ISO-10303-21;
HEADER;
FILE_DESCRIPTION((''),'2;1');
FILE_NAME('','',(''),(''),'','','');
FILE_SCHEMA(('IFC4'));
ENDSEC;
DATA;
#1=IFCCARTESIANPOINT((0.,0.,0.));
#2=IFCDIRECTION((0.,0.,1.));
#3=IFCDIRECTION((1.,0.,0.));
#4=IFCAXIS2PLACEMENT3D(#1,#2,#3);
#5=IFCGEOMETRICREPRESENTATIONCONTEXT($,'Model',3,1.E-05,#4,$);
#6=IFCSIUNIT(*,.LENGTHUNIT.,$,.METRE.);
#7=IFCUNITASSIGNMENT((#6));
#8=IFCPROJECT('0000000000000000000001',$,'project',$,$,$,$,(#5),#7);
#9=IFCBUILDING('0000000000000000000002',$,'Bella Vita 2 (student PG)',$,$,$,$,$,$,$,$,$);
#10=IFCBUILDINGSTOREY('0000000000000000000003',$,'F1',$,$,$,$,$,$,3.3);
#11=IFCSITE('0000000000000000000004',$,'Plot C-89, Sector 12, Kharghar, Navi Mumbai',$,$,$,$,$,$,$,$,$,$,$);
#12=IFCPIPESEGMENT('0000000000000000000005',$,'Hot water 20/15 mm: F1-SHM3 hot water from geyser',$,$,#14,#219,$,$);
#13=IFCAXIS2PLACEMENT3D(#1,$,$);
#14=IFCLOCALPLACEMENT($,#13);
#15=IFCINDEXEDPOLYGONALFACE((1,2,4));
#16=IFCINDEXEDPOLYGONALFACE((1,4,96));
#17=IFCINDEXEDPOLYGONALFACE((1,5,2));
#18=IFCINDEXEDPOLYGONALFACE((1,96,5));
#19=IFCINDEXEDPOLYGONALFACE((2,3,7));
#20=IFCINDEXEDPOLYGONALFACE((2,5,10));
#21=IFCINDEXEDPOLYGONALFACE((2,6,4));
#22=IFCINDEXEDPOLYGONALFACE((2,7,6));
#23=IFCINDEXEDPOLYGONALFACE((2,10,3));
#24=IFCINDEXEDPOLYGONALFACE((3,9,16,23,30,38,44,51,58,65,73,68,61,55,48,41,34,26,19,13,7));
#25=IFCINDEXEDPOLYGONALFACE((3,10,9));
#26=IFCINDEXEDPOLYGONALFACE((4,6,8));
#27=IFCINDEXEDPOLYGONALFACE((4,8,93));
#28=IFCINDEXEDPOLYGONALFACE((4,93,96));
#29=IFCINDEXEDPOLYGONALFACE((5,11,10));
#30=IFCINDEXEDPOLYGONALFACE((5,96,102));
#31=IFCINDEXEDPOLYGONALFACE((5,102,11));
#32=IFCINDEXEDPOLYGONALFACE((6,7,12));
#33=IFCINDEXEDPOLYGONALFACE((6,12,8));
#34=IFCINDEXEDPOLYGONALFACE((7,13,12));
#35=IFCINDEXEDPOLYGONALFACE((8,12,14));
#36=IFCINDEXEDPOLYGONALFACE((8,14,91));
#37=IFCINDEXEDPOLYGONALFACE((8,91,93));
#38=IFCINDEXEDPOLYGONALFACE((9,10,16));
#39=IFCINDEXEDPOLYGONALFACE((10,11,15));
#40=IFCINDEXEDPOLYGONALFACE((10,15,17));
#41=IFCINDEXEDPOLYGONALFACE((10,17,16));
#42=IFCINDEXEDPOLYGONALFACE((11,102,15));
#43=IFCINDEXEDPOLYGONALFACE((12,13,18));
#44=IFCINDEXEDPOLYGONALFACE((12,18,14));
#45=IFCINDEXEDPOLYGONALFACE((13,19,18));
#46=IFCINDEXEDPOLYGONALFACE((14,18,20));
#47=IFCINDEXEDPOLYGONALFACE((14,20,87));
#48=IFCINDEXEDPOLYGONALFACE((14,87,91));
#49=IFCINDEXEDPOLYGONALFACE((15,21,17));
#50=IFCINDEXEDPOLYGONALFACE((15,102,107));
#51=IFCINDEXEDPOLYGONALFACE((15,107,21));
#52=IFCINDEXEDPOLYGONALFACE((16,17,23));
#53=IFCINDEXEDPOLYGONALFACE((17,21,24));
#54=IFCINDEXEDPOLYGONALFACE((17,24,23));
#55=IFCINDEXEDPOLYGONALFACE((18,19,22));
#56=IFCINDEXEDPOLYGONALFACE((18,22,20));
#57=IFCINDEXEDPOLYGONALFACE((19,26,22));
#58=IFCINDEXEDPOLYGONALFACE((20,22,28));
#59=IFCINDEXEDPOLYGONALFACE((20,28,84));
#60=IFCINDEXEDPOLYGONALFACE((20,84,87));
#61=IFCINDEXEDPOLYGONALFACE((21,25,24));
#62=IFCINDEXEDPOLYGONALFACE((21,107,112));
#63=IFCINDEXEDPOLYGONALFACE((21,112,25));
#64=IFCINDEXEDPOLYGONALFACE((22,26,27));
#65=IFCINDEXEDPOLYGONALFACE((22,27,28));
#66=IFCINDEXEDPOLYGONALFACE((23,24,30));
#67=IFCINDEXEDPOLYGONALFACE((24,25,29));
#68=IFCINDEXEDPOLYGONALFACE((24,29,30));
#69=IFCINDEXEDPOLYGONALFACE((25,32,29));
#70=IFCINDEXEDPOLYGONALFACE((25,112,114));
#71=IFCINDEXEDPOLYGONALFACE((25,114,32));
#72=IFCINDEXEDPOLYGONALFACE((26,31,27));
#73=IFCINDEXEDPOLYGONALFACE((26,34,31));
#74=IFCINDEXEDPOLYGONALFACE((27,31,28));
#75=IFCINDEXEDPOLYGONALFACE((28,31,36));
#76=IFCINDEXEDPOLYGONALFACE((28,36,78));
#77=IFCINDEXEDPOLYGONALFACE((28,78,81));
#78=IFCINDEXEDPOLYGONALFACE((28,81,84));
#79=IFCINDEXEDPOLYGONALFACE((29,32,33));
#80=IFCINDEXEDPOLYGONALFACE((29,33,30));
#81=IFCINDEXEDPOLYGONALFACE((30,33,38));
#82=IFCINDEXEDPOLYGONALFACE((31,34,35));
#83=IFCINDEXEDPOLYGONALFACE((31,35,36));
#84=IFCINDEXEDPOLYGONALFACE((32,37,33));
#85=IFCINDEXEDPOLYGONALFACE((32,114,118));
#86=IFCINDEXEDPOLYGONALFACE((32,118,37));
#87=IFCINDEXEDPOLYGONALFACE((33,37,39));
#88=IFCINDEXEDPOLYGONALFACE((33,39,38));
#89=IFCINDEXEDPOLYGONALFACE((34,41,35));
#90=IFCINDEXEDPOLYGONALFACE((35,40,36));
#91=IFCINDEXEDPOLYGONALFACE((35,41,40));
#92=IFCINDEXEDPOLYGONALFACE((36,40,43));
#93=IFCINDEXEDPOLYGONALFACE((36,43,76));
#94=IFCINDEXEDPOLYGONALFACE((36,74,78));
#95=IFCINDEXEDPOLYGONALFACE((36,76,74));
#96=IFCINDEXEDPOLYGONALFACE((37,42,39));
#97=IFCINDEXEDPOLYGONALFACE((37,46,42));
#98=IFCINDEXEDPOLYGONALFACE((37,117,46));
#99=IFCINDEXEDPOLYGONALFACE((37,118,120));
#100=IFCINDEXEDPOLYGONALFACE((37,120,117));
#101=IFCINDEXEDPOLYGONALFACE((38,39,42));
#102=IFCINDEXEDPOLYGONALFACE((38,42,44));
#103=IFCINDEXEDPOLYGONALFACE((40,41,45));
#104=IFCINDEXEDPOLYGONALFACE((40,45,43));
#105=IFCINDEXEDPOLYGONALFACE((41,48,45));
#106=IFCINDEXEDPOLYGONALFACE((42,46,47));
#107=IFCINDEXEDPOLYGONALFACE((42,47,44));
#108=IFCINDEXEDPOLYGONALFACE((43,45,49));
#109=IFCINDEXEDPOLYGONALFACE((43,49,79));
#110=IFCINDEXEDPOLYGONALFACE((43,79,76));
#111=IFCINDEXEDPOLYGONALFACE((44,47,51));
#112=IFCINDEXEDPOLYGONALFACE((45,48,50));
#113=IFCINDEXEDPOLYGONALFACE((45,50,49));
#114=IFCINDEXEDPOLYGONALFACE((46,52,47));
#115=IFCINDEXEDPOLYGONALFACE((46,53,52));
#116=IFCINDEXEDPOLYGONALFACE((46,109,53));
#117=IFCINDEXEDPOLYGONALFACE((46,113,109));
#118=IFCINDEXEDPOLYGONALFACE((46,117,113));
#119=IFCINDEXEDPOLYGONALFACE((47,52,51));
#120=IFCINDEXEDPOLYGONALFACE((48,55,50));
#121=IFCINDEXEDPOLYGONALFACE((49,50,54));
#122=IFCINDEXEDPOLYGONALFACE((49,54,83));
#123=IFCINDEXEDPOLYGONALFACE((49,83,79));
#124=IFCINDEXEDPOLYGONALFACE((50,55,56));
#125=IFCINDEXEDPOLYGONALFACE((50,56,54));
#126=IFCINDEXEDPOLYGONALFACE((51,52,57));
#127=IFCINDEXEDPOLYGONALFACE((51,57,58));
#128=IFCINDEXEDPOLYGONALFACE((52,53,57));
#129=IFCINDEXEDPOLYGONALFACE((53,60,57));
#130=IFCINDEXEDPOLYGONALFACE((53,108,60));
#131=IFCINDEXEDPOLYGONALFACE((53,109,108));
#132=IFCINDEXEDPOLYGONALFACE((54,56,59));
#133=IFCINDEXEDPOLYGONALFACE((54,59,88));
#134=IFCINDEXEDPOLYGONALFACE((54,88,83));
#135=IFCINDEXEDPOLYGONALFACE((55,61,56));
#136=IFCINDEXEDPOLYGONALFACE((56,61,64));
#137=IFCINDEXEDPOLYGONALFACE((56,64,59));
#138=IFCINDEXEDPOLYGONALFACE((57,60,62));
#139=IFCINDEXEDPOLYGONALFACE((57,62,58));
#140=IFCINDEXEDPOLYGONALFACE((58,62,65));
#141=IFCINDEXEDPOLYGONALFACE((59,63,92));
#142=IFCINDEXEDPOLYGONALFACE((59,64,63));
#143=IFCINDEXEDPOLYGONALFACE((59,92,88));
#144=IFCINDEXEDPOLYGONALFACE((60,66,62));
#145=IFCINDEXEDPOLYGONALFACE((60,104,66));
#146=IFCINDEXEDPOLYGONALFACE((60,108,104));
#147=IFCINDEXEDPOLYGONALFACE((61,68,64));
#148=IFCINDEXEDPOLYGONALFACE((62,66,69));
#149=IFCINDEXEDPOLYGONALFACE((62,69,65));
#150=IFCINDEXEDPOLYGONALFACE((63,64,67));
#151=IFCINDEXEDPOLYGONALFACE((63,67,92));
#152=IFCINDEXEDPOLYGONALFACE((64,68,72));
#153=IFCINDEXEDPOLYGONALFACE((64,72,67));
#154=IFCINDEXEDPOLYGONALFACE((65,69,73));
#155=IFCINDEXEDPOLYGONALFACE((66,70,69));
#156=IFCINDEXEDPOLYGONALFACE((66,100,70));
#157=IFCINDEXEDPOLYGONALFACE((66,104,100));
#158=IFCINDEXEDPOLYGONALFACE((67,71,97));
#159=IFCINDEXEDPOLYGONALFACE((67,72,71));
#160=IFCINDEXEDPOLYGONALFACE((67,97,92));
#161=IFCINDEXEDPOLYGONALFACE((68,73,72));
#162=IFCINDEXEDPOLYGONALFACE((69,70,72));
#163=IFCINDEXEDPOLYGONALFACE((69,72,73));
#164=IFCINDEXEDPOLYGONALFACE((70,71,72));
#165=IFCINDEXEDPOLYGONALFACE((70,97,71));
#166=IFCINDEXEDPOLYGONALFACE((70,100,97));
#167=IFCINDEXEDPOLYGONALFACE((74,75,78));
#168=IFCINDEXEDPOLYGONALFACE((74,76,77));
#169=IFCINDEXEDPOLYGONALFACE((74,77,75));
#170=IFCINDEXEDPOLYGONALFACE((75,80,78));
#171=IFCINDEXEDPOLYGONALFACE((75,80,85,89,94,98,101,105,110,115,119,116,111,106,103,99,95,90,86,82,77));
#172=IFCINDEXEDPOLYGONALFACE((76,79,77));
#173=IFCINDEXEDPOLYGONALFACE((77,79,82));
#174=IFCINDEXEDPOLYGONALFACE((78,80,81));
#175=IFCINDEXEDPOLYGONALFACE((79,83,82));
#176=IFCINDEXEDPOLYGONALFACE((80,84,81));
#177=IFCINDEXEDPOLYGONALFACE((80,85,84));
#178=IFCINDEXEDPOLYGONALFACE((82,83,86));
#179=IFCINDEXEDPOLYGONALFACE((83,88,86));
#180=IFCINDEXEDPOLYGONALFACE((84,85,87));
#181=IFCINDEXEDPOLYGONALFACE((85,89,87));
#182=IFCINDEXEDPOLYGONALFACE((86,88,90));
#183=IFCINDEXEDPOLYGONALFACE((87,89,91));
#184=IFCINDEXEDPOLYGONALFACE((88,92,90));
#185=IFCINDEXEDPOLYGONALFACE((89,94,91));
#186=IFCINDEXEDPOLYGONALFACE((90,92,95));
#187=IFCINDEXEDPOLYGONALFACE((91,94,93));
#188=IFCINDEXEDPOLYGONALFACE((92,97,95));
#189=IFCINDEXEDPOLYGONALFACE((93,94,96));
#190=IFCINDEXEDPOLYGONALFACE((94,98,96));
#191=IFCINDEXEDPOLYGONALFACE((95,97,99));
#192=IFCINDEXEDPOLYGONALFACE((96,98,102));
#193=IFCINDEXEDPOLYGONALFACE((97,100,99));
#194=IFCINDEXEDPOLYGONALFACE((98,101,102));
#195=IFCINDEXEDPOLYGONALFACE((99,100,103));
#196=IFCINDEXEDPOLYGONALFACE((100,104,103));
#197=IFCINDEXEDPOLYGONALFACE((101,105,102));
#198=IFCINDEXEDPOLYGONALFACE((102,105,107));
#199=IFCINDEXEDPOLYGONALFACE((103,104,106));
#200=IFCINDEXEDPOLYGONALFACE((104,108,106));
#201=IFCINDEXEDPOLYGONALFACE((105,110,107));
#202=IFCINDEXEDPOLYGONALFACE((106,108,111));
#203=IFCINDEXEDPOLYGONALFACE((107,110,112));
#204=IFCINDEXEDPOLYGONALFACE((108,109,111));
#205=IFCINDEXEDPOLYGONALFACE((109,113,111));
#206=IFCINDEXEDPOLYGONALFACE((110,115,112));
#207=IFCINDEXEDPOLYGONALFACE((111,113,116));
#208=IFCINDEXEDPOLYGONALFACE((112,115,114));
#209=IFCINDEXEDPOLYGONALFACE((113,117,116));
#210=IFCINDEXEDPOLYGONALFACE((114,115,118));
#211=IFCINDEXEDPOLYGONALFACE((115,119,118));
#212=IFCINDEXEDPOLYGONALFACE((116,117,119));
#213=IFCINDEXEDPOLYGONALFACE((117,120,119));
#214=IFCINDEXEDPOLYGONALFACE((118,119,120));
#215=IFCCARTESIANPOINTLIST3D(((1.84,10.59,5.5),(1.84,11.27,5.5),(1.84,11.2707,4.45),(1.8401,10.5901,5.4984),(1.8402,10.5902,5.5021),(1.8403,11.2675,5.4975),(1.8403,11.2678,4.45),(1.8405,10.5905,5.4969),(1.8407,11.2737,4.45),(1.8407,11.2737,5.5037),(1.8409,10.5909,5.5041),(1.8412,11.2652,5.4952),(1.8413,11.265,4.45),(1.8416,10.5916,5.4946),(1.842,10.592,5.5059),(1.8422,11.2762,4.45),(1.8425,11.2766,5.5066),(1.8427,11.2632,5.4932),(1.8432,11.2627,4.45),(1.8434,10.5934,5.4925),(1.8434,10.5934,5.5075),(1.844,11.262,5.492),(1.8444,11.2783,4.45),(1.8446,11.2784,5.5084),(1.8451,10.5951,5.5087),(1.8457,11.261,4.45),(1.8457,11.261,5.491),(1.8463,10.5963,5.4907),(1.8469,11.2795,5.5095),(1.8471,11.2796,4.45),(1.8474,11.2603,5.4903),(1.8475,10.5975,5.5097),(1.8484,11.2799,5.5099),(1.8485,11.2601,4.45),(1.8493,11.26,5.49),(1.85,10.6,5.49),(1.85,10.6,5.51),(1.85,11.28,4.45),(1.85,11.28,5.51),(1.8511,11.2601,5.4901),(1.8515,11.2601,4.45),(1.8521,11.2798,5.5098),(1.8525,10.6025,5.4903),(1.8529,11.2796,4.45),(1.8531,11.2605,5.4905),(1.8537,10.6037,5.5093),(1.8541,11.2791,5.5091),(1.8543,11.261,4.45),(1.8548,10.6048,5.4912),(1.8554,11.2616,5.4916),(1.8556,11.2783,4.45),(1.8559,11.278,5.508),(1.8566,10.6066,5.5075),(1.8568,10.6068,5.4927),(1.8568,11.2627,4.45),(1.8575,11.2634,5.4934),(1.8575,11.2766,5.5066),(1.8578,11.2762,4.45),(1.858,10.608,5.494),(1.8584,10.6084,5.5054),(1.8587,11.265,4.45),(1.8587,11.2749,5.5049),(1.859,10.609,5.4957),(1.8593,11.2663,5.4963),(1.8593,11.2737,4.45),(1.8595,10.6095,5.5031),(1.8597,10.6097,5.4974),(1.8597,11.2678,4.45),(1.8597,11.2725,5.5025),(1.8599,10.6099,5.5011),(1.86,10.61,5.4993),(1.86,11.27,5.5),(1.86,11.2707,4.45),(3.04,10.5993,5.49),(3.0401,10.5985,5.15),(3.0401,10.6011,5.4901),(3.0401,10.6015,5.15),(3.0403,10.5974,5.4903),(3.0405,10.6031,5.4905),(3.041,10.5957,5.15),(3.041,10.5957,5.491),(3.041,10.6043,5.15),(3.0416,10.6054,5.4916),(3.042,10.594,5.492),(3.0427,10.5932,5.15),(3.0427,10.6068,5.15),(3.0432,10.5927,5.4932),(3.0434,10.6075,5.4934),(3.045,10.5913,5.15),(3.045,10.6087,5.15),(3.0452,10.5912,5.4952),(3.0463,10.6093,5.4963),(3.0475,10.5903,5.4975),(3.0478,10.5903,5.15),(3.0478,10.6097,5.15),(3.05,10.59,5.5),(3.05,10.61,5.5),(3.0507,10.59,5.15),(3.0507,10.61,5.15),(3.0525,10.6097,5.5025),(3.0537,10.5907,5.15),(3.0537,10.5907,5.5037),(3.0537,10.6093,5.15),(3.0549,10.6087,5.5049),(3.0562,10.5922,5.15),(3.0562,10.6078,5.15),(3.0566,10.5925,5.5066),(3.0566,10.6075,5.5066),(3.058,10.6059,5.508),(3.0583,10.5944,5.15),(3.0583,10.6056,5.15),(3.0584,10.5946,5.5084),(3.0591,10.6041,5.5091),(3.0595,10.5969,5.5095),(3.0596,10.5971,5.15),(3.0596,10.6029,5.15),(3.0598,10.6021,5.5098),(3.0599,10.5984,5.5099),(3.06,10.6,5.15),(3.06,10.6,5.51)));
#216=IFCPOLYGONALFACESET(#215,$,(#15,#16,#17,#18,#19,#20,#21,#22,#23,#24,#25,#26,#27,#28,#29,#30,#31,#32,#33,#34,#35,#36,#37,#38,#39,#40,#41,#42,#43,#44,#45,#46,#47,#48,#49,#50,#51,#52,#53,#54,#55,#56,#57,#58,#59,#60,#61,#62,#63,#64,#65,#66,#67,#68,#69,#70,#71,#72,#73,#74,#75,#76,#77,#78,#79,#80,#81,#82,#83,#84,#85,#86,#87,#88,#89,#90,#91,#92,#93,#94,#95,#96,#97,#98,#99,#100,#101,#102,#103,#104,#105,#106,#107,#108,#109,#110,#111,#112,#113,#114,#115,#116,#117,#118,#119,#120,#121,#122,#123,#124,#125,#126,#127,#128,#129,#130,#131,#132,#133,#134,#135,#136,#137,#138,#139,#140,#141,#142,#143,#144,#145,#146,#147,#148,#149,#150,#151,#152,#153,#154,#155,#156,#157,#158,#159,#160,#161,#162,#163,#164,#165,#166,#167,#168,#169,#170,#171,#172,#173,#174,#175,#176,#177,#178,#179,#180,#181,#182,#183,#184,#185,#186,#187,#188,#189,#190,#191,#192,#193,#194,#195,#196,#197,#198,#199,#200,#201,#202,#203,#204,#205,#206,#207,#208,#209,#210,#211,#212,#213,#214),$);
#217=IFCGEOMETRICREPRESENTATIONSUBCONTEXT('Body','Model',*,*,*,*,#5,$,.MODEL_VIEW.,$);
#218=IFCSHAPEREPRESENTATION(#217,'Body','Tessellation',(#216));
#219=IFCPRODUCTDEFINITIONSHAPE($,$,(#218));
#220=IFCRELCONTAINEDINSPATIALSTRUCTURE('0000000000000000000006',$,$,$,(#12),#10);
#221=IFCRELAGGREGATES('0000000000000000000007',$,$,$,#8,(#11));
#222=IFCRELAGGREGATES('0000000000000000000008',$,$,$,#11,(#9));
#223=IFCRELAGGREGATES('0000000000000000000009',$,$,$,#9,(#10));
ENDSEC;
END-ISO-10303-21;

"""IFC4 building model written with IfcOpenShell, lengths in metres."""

from ifc_helpers import new_model, entity, si_unit, origin, origin_with_axes, place, context, subcontext, project, spatial, element, save


model = new_model("IFC4")

# Units and contexts
model_context = context("Model", 3, precision=1e-05, world=origin_with_axes())
body_context = subcontext(model_context, "Body", "Model", "MODEL_VIEW")
ifc_project = project(units=[si_unit("LENGTHUNIT", "METRE")], contexts=[model_context])

# Site, building, storey
site = spatial("IfcSite", under=ifc_project, Name="Plot C-89, Sector 12, Kharghar, Navi Mumbai")
building = spatial("IfcBuilding", under=site, Name="Bella Vita 2 (student PG)")
storey = spatial("IfcBuildingStorey", under=building, Name="F1", Elevation=3.3)

# Pipe segment
pipe_segment_1_placement = place(None, origin())
element("IfcPipeSegment", 1, at=pipe_segment_1_placement, inside=storey, Name="Hot water 20/15 mm: F1-SHM3 hot water from geyser", context=body_context, shape_type="AdvancedSweptSolid", body=[
    entity("IfcSweptDiskSolid", entity("IfcPolyline", [entity("IfcCartesianPoint", [3.05, 10.6, 5.15]), entity("IfcCartesianPoint", [3.05, 10.6, 5.5]), entity("IfcCartesianPoint", [1.85, 10.6, 5.5]), entity("IfcCartesianPoint", [1.85, 11.27, 5.5]), entity("IfcCartesianPoint", [1.85, 11.27, 4.45])]), 0.01),
])

save(model, "model.ifc")
